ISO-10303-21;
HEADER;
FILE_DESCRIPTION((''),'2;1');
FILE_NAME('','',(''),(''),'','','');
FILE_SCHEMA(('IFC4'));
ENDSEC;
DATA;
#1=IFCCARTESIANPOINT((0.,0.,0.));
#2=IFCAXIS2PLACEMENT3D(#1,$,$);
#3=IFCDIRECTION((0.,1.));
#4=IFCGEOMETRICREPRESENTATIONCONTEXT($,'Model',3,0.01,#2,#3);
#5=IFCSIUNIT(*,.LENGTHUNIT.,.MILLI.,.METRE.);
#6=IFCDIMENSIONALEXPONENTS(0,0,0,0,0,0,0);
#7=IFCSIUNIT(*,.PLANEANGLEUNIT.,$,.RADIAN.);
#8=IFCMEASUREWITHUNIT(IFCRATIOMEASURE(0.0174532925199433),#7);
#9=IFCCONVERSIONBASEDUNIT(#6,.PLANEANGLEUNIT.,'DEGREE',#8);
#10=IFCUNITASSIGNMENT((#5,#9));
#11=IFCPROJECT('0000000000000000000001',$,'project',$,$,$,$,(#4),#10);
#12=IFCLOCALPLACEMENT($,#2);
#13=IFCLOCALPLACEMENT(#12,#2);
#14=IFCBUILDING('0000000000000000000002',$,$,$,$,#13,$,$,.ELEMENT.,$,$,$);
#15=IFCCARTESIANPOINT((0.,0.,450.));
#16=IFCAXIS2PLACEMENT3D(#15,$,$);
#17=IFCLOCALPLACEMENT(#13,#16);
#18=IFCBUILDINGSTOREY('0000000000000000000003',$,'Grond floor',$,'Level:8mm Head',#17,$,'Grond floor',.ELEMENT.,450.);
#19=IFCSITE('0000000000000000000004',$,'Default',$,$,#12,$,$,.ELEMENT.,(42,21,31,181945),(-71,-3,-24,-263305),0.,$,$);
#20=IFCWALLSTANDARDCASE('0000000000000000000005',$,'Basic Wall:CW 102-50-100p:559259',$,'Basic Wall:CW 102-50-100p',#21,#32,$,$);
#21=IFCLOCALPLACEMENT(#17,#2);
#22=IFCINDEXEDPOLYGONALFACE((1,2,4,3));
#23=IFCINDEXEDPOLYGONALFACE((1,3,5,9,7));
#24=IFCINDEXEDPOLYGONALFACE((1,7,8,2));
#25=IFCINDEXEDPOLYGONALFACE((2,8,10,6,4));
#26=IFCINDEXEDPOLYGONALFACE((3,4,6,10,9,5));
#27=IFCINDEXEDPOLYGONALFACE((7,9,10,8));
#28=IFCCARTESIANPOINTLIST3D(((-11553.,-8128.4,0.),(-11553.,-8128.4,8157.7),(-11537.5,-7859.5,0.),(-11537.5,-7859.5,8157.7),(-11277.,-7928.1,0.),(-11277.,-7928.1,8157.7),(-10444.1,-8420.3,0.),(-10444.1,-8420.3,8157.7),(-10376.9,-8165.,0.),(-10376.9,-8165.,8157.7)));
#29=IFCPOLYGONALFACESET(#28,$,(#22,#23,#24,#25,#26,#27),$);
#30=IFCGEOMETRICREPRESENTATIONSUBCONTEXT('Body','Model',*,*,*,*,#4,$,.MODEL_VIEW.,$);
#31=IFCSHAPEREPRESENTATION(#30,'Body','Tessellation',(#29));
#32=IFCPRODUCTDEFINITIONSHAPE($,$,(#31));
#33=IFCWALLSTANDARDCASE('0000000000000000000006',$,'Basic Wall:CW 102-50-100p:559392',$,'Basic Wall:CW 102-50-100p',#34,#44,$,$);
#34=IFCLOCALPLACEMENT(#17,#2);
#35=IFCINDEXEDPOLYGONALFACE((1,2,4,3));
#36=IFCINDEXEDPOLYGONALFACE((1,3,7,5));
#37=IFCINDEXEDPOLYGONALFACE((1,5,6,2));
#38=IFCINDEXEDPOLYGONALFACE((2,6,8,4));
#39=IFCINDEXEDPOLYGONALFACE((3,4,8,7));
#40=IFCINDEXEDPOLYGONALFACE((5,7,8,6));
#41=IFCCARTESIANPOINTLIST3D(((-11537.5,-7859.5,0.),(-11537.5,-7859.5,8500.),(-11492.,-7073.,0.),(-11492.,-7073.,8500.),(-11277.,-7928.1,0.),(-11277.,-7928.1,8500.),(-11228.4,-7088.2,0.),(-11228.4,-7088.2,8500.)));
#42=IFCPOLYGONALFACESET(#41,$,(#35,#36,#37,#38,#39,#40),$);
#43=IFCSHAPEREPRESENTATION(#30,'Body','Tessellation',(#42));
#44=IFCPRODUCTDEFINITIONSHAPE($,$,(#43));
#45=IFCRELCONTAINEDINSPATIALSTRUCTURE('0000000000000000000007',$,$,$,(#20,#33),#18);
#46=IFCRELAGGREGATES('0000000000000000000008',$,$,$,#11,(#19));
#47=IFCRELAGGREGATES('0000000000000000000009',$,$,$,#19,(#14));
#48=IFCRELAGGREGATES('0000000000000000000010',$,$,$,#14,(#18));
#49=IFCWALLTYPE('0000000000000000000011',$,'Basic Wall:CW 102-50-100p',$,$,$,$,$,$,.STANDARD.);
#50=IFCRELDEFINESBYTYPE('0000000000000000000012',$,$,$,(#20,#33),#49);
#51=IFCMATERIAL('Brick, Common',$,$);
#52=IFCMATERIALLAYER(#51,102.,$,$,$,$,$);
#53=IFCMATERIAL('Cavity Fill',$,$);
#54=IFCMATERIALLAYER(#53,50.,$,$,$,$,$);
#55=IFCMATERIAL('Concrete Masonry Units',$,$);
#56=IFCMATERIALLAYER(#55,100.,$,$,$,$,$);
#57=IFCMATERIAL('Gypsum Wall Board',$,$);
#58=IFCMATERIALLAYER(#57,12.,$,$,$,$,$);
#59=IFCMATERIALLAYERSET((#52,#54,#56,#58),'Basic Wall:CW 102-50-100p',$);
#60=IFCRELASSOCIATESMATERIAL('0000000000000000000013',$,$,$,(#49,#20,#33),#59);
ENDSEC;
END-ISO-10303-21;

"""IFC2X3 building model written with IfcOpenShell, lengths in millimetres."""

from ifc_helpers import new_model, entity, si_unit, converted_unit, direction, frame, origin, place, context, subcontext, project, spatial, polyline, outline, extrude, material, layer, layer_set, layer_usage, type_object, element, save


model = new_model("IFC2X3")

# Units and contexts
model_context = context("Model", 3, precision=0.01, world=origin(), true_north=direction((0.0, 1.0)))
body_context = subcontext(model_context, "Body", "Model", "MODEL_VIEW")
ifc_project = project(units=[si_unit("LENGTHUNIT", "METRE", prefix="MILLI"), converted_unit("PLANEANGLEUNIT", "DEGREE", entity("IfcRatioMeasure", 0.0174532925199433), si_unit("PLANEANGLEUNIT", "RADIAN"), dimensions=[0, 0, 0, 0, 0, 0, 0])], contexts=[model_context])

# Site, building, storey
site_placement = place(None, origin())
site = spatial("IfcSite", under=ifc_project, at=site_placement, Name="Default", CompositionType="ELEMENT", RefLatitude=(42, 21, 31, 181945), RefLongitude=(-71, -3, -24, -263305), RefElevation=0.0)
building_placement = place(site_placement, origin())
building = spatial("IfcBuilding", under=site, at=building_placement, CompositionType="ELEMENT")
storey_placement = place(building_placement, frame((0.0, 0.0, 450.0)))
storey = spatial("IfcBuildingStorey", under=building, at=storey_placement, Name="Grond floor", ObjectType="Level:8mm Head", LongName="Grond floor", CompositionType="ELEMENT", Elevation=450.0)

# Walls
ifc_material_1 = material(Name="Brick, Common")
ifc_layer_1 = layer(ifc_material_1, 102.0)
ifc_material_2 = material(Name="Cavity Fill")
ifc_layer_2 = layer(ifc_material_2, 50.0)
ifc_material_3 = material(Name="Concrete Masonry Units")
ifc_layer_3 = layer(ifc_material_3, 100.0)
ifc_material_4 = material(Name="Gypsum Wall Board")
ifc_layer_4 = layer(ifc_material_4, 12.0)
ifc_layer_set = layer_set([ifc_layer_1, ifc_layer_2, ifc_layer_3, ifc_layer_4], Name="Basic Wall:CW 102-50-100p")
ifc_layer_usage_1 = layer_usage(ifc_layer_set, "AXIS2", "POSITIVE", -132.0)
wall_type = type_object("IfcWallType", Name="Basic Wall:CW 102-50-100p", PredefinedType="STANDARD", material=ifc_layer_set)
wall_1_placement = place(storey_placement, frame((-11571.1, -7987.2, 0.0), z_axis=(0.0, 0.0, 1.0), x_axis=(0.967067, -0.25452, 0.0)))
element("IfcWallStandardCase", 1, at=wall_1_placement, inside=storey, type_object=wall_type, material=ifc_layer_usage_1, Name="Basic Wall:CW 102-50-100p:559259", ObjectType="Basic Wall:CW 102-50-100p", context=body_context, shape_type="SweptSolid", body=[
    extrude(outline(polyline([(1200.1, -132.0), (1200.1, 132.0), (269.3, 132.0), (0.0, 132.0), (53.4, -132.0), (1200.1, -132.0)])), origin(), (0.0, 0.0, 1.0), 8157.7),
])
ifc_layer_usage_2 = layer_usage(ifc_layer_set, "AXIS2", "POSITIVE", -132.0)
wall_2_placement = place(storey_placement, frame((-11360.2, -7080.6, 0.0), z_axis=(0.0, 0.0, 1.0), x_axis=(-0.057751, -0.998331, 0.0)))
element("IfcWallStandardCase", 2, at=wall_2_placement, inside=storey, type_object=wall_type, material=ifc_layer_usage_2, Name="Basic Wall:CW 102-50-100p:559392", ObjectType="Basic Wall:CW 102-50-100p", context=body_context, shape_type="SweptSolid", body=[
    extrude(outline(polyline([(787.9, -132.0), (841.3, 132.0), (0.0, 132.0), (0.0, -132.0), (787.9, -132.0)])), origin(), (0.0, 0.0, 1.0), 8500.0),
])

save(model, "model.ifc")
